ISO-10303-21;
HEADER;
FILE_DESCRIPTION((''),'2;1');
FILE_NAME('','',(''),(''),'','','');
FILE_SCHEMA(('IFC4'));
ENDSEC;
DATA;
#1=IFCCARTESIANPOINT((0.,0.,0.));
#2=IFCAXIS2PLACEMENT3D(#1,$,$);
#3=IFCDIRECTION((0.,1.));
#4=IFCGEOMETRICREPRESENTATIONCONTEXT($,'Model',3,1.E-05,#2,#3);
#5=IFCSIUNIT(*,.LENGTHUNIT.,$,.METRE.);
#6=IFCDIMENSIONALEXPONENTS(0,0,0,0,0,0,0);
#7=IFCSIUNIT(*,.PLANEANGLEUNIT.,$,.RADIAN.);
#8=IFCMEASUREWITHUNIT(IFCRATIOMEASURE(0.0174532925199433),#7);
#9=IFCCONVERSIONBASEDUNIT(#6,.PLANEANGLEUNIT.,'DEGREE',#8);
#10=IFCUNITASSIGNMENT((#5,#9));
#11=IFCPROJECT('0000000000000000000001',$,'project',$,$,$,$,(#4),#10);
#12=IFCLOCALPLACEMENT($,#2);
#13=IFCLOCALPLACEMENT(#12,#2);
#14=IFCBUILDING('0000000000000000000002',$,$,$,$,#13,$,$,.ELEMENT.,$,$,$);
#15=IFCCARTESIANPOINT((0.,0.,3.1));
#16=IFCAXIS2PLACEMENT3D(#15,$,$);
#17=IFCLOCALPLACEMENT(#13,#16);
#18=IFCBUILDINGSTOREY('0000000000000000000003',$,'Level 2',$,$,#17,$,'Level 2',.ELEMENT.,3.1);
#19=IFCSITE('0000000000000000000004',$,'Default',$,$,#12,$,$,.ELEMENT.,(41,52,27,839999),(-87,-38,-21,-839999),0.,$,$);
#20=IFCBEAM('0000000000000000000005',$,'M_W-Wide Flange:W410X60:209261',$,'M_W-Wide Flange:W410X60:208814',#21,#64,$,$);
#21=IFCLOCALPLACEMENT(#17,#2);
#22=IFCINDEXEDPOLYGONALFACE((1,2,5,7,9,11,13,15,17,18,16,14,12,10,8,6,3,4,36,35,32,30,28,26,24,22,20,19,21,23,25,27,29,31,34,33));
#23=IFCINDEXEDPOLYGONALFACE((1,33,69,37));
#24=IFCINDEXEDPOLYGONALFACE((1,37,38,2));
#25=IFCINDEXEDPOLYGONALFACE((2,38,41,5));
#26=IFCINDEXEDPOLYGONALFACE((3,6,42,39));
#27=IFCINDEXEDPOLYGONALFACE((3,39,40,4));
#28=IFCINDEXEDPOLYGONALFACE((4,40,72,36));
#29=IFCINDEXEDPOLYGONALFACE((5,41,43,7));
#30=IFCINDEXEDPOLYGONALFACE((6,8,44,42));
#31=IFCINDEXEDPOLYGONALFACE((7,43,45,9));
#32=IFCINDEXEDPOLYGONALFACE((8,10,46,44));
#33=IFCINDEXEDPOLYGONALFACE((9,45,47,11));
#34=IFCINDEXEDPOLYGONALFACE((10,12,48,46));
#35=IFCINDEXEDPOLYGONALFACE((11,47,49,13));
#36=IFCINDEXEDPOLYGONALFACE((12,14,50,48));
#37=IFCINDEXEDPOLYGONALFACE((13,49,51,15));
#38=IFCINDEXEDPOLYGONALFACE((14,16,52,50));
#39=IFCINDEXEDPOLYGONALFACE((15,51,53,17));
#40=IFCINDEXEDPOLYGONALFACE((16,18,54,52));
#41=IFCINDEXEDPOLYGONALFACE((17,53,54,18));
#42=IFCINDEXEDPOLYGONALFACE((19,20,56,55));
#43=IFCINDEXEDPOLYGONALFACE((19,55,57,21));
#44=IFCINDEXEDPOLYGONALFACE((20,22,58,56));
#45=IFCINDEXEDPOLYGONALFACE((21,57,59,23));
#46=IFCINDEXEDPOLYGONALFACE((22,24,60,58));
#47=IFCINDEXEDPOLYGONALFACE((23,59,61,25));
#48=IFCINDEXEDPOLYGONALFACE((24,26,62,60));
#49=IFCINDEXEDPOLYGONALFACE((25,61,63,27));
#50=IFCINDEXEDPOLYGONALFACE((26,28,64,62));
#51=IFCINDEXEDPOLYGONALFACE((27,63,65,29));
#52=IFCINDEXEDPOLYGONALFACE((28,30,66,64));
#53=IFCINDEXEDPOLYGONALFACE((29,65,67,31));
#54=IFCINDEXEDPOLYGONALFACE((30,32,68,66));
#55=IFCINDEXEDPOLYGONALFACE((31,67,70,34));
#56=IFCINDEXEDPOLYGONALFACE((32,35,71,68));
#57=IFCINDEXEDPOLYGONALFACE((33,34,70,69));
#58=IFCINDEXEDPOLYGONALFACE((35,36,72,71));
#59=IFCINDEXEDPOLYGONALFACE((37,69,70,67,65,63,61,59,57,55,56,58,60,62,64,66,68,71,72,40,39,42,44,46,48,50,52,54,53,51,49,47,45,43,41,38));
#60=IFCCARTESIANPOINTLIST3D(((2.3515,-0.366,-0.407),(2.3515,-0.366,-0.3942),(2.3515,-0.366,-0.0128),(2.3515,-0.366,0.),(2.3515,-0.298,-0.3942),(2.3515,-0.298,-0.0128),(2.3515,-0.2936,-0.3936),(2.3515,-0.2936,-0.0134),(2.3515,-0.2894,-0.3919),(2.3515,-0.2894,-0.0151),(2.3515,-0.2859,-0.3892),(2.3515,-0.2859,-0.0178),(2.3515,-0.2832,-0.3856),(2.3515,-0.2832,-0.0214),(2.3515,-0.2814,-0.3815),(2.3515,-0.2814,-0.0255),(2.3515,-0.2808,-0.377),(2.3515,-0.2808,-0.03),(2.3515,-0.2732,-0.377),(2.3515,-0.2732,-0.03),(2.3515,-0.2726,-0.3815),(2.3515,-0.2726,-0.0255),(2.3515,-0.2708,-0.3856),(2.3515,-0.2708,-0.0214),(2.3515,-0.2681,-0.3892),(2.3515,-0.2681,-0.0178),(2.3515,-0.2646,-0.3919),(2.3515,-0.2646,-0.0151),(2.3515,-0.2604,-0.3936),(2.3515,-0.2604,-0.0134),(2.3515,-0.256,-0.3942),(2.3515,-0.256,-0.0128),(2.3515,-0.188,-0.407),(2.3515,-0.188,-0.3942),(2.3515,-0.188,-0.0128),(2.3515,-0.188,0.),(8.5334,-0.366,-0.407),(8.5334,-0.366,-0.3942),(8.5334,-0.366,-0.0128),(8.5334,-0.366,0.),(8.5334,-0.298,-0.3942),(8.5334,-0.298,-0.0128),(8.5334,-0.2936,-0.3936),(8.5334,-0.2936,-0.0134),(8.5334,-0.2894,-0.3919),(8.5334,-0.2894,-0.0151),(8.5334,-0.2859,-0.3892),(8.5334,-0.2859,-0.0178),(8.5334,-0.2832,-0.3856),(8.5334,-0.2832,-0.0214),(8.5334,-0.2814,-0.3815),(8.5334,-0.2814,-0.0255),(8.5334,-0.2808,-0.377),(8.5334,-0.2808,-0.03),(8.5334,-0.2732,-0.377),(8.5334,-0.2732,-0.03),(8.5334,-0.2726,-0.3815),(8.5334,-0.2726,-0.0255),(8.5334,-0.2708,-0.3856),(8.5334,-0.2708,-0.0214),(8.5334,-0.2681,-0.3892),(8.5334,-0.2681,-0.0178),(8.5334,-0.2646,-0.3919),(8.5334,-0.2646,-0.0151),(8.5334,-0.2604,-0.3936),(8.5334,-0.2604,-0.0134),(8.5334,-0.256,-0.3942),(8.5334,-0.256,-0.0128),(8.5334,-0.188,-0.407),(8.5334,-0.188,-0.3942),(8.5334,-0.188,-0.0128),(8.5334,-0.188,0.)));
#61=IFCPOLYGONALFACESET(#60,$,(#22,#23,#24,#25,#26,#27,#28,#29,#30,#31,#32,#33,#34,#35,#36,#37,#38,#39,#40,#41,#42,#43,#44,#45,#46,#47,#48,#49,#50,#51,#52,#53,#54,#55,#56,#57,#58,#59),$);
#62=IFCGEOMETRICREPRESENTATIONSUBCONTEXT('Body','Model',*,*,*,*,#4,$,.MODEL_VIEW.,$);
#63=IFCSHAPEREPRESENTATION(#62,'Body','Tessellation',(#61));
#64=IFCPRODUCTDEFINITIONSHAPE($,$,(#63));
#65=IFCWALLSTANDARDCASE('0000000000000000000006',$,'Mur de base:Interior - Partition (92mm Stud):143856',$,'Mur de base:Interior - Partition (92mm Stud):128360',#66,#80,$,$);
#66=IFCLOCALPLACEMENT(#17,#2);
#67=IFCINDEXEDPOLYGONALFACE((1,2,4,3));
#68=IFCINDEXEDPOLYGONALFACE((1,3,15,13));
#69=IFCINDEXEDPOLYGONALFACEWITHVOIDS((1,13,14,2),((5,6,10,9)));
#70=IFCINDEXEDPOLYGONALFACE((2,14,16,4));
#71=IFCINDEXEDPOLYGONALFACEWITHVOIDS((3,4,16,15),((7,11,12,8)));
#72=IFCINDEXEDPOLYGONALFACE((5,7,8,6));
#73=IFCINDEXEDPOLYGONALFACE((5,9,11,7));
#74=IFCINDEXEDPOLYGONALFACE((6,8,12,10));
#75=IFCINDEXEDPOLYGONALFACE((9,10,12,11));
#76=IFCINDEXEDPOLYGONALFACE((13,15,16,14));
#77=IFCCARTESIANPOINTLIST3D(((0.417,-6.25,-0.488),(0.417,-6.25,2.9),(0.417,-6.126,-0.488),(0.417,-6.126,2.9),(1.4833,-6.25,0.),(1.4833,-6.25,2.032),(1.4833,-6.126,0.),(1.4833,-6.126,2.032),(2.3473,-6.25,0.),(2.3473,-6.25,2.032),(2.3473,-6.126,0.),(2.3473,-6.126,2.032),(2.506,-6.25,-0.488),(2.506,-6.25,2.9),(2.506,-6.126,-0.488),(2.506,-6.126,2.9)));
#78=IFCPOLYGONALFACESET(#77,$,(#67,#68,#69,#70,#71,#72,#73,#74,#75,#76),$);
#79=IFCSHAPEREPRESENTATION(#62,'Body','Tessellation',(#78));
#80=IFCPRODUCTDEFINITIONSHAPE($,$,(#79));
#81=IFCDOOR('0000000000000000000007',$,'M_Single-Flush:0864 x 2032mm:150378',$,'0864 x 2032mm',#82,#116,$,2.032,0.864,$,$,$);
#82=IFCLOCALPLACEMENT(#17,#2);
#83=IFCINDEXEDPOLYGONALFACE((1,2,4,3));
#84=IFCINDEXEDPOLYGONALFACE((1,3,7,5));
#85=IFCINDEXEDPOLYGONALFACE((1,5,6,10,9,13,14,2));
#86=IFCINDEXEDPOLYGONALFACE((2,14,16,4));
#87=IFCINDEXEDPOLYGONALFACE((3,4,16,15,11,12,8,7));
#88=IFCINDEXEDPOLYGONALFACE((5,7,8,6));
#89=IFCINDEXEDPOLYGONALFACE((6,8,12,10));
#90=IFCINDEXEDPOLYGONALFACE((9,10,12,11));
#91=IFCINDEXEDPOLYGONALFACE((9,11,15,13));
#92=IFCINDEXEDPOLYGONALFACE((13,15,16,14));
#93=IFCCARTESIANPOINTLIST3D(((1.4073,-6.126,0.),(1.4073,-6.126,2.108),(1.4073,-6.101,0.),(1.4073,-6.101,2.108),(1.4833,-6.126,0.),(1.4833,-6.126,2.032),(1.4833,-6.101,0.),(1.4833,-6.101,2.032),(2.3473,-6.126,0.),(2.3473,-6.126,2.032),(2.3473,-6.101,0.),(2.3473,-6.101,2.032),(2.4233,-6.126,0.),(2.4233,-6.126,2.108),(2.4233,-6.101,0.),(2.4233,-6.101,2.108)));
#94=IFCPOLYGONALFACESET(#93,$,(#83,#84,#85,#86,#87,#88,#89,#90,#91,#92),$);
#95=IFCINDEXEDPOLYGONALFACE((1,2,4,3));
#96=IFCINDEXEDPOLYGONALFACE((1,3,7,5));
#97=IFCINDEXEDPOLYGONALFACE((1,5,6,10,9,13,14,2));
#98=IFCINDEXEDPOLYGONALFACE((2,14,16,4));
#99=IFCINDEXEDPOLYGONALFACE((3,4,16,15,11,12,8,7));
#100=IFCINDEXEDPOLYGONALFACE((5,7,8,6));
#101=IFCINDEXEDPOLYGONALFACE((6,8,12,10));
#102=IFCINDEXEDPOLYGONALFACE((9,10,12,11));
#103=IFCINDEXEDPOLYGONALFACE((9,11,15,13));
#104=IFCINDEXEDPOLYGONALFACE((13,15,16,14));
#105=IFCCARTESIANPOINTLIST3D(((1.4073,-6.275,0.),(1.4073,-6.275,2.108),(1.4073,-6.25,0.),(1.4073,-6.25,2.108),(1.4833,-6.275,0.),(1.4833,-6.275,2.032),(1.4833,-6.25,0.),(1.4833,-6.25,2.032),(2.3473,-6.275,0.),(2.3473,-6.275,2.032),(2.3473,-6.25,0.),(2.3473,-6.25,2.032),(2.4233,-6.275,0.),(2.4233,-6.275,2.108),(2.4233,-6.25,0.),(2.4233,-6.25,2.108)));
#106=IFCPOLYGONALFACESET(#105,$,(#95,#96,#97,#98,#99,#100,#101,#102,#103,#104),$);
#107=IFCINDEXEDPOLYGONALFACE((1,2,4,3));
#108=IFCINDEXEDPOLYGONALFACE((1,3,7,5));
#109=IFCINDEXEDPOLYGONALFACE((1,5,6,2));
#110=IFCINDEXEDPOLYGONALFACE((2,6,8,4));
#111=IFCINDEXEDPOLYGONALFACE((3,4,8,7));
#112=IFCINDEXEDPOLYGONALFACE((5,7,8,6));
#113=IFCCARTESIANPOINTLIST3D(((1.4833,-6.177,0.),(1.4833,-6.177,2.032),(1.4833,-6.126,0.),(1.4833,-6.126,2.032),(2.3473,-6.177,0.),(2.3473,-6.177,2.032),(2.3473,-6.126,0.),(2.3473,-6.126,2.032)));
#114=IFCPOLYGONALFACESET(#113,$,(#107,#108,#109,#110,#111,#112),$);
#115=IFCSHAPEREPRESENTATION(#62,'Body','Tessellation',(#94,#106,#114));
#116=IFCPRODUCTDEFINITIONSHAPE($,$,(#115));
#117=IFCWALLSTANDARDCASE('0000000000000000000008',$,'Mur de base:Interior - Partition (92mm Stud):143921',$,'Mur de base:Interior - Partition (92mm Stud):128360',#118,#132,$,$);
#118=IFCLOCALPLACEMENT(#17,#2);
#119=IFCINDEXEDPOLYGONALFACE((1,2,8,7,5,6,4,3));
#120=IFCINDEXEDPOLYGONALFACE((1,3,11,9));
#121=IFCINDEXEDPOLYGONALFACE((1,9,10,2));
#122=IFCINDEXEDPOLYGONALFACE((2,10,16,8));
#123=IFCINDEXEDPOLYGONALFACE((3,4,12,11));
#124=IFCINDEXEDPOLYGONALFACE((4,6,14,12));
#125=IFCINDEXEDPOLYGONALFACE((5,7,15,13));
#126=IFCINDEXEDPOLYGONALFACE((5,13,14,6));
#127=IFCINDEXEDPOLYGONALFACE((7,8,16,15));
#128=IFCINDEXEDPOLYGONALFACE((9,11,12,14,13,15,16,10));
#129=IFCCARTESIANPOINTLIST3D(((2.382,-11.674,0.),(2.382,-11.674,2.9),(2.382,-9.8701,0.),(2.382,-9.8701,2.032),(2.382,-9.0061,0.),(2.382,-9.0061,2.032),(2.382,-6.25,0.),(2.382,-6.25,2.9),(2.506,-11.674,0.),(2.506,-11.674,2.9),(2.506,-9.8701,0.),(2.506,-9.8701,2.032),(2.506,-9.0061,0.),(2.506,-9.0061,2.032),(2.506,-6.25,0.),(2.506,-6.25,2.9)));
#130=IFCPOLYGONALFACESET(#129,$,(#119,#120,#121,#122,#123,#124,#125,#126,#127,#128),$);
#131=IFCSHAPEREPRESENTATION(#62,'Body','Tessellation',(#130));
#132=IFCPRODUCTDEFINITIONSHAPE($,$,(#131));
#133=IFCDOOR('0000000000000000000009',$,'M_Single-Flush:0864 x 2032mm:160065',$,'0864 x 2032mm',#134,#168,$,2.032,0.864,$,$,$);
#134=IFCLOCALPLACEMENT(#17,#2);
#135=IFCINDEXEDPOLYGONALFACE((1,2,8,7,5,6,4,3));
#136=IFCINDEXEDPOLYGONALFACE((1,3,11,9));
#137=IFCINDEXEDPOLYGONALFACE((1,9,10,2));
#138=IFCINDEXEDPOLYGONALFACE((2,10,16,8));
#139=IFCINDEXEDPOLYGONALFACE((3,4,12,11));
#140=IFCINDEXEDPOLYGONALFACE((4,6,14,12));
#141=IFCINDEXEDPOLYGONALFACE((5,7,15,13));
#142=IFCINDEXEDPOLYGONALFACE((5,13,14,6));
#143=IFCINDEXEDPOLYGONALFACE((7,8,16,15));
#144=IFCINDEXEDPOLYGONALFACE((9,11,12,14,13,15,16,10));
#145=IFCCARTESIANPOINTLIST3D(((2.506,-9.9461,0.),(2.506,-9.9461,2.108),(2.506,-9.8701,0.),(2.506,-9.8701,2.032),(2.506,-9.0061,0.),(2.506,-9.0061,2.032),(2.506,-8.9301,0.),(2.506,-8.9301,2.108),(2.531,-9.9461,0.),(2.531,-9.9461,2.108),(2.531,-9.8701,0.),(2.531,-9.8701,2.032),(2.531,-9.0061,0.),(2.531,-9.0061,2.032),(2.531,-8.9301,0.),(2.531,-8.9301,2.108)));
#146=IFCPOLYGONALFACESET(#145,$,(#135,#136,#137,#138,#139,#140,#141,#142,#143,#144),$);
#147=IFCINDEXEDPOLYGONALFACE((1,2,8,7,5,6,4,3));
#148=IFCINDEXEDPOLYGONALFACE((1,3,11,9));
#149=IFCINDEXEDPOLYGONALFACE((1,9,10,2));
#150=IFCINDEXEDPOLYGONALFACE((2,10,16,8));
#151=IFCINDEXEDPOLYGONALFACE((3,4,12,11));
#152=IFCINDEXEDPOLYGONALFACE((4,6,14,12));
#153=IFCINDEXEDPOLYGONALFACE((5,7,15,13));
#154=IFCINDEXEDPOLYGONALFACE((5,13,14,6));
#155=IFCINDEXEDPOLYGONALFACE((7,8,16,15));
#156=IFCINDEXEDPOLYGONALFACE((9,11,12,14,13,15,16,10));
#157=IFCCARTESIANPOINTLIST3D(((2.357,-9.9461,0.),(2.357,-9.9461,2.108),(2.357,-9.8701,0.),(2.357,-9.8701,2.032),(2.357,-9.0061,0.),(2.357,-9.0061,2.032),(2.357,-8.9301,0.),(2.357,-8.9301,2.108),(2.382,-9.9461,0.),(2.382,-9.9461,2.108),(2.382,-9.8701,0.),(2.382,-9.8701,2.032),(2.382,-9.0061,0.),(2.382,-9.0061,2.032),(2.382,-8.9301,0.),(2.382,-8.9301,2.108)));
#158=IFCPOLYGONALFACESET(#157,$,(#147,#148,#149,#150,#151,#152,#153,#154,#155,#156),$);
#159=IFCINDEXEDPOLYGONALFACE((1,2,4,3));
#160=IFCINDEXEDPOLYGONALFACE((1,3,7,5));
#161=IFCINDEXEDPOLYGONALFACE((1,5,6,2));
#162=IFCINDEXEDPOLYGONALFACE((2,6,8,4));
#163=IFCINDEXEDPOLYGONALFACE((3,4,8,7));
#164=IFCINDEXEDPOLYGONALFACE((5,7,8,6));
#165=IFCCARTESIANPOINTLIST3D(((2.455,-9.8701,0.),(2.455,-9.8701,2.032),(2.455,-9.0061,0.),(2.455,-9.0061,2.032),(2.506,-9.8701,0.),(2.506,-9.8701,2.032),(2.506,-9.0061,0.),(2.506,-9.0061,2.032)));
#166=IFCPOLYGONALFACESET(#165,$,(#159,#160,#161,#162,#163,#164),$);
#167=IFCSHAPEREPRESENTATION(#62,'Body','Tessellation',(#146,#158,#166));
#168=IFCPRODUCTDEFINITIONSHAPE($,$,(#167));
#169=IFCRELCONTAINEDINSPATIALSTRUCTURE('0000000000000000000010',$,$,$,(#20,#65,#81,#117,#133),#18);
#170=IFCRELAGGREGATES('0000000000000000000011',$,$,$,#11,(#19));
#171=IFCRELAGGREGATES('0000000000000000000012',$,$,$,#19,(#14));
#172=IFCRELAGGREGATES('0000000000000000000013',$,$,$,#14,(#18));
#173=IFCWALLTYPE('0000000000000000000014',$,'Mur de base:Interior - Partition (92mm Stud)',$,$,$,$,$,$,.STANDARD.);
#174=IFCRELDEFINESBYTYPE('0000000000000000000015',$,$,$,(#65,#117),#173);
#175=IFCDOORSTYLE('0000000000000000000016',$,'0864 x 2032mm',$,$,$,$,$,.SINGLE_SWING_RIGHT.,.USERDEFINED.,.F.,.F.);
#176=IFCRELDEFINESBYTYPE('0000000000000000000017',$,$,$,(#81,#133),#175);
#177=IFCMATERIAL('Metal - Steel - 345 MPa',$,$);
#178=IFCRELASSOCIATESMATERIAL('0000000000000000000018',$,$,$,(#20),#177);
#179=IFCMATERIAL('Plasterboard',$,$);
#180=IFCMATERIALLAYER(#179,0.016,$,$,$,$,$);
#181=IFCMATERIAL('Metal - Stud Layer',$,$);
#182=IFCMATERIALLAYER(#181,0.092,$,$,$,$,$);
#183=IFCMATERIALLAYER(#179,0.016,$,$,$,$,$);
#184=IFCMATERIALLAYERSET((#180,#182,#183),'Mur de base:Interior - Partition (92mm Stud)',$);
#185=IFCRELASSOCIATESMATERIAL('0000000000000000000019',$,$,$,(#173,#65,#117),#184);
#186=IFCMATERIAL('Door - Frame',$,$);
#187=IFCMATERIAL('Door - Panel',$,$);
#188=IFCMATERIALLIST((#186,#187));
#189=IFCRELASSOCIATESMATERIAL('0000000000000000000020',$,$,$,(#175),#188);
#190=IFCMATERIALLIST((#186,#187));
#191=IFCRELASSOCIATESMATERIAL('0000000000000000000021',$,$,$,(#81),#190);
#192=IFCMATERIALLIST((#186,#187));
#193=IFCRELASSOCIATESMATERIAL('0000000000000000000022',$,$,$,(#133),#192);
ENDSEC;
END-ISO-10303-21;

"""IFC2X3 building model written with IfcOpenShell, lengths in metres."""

from ifc_helpers import new_model, entity, si_unit, converted_unit, direction, frame, frame_2d, origin, origin_2d_with_axis, place, context, subcontext, project, spatial, polyline, rectangle, i_section, outline, extrude, source, transform, mapped, material, material_list, layer, layer_set, layer_usage, type_object, type_shapes, element, fill, save


model = new_model("IFC2X3")

# Units and contexts
model_context = context("Model", 3, precision=1e-05, world=origin(), true_north=direction((0.0, 1.0)))
body_context = subcontext(model_context, "Body", "Model", "MODEL_VIEW")
ifc_project = project(units=[si_unit("LENGTHUNIT", "METRE"), converted_unit("PLANEANGLEUNIT", "DEGREE", entity("IfcRatioMeasure", 0.0174532925199433), si_unit("PLANEANGLEUNIT", "RADIAN"), dimensions=[0, 0, 0, 0, 0, 0, 0])], contexts=[model_context])

# Site, building, storey
site_placement = place(None, origin())
site = spatial("IfcSite", under=ifc_project, at=site_placement, Name="Default", CompositionType="ELEMENT", RefLatitude=(41, 52, 27, 839999), RefLongitude=(-87, -38, -21, -839999), RefElevation=0.0)
building_placement = place(site_placement, origin())
building = spatial("IfcBuilding", under=site, at=building_placement, CompositionType="ELEMENT")
storey_placement = place(building_placement, frame((0.0, 0.0, 3.1)))
storey = spatial("IfcBuildingStorey", under=building, at=storey_placement, Name="Level 2", LongName="Level 2", CompositionType="ELEMENT", Elevation=3.1)

# Beam
ifc_material_1 = material(Name="Metal - Steel - 345 MPa")
beam_placement = place(storey_placement, frame((8.5334, -0.277, 0.0), z_axis=(0.0, 0.0, 1.0), x_axis=(-1.0, 0.0, 0.0)))
element("IfcBeam", 1, at=beam_placement, inside=storey, material=ifc_material_1, Name="M_W-Wide Flange:W410X60:209261", ObjectType="M_W-Wide Flange:W410X60:208814", context=body_context, shape_type="SweptSolid", body=[
    extrude(i_section(OverallWidth=0.178, OverallDepth=0.407, WebThickness=0.0077, FlangeThickness=0.0128, FilletRadius=0.0172, at=frame_2d((0.0, 0.0), x_axis=(0.0, 1.0))), frame((0.0, 0.0, -0.2035), z_axis=(1.0, 0.0, 0.0), x_axis=(0.0, 0.0, -1.0)), (0.0, 0.0, 1.0), 6.1819),
])

# Shared definitions
ifc_material_2 = material(Name="Metal - Stud Layer")
ifc_material_3 = material(Name="Plasterboard")

# Walls, openings, doors
ifc_layer_1 = layer(ifc_material_3, 0.016)
ifc_layer_2 = layer(ifc_material_2, 0.092)
ifc_layer_3 = layer(ifc_material_3, 0.016)
ifc_layer_set_1 = layer_set([ifc_layer_1, ifc_layer_2, ifc_layer_3], Name="Mur de base:Interior - Partition (92mm Stud)")
ifc_layer_usage_1 = layer_usage(ifc_layer_set_1, "AXIS2", "NEGATIVE", 0.062)
wall_type_1 = type_object("IfcWallType", Name="Mur de base:Interior - Partition (92mm Stud)", PredefinedType="STANDARD", material=ifc_layer_set_1)
wall_1_placement = place(storey_placement, frame((0.417, -6.188, -0.488)))
wall_1 = element("IfcWallStandardCase", 2, at=wall_1_placement, inside=storey, type_object=wall_type_1, material=ifc_layer_usage_1, Name="Mur de base:Interior - Partition (92mm Stud):143856", ObjectType="Mur de base:Interior - Partition (92mm Stud):128360", context=body_context, shape_type="SweptSolid", body=[
    extrude(rectangle(XDim=2.089, YDim=0.124, at=frame_2d((1.0445, 0.0), x_axis=(-1.0, 0.0))), origin(), (0.0, 0.0, 1.0), 3.388),
])
opening_1_placement = place(wall_1_placement, frame((1.0663, -0.062, 0.488)))
opening_1 = element("IfcOpeningElement", 3, at=opening_1_placement, cuts=wall_1, ObjectType="Opening", context=body_context, shape_type="SweptSolid", body=[
    extrude(rectangle(XDim=0.864, YDim=2.032, at=frame_2d((1.016, 0.432), x_axis=(0.0, 1.0))), frame((0.0, 0.0, 0.0), z_axis=(0.0, 1.0, 0.0), x_axis=(0.0, 0.0, 1.0)), (0.0, 0.0, 1.0), 0.124),
])
ifc_material_4 = material(Name="Door - Frame")
ifc_material_5 = material(Name="Door - Panel")
ifc_material_list_1 = material_list([ifc_material_4, ifc_material_5])
ifc_material_list_2 = material_list([ifc_material_4, ifc_material_5])
door_style_1 = type_object("IfcDoorStyle", Name="0864 x 2032mm", ConstructionType="USERDEFINED", OperationType="SINGLE_SWING_RIGHT", ParameterTakesPrecedence=False, Sizeable=False, material=ifc_material_list_2)
shared_shape_1 = source(origin(), body_context, "Body", "SweptSolid", [
    extrude(outline(polyline([(-0.508, -1.073), (0.508, -1.073), (0.508, 1.035), (0.432, 1.035), (0.432, -0.997), (-0.432, -0.997), (-0.432, 1.035), (-0.508, 1.035), (-0.508, -1.073)])), frame((0.432, 0.124, 1.035), z_axis=(0.0, 1.0, 0.0), x_axis=(1.0, 0.0, 0.0)), (0.0, 0.0, 1.0), 0.025),
    extrude(outline(polyline([(-1.073, -0.508), (1.035, -0.508), (1.035, -0.432), (-0.997, -0.432), (-0.997, 0.432), (1.035, 0.432), (1.035, 0.508), (-1.073, 0.508), (-1.073, -0.508)])), frame((0.432, -0.025, 1.035), z_axis=(0.0, 1.0, 0.0), x_axis=(0.0, 0.0, -1.0)), (0.0, 0.0, 1.0), 0.025),
    extrude(rectangle(XDim=0.051, YDim=0.864, at=origin_2d_with_axis()), frame((0.432, 0.0985, 0.0), z_axis=(0.0, 0.0, 1.0), x_axis=(0.0, 1.0, 0.0)), (0.0, 0.0, 1.0), 2.032),
])
type_shapes(door_style_1, [shared_shape_1])
door_1_placement = place(opening_1_placement, origin())
door_1 = element("IfcDoor", 4, at=door_1_placement, inside=storey, type_object=door_style_1, material=ifc_material_list_1, Name="M_Single-Flush:0864 x 2032mm:150378", ObjectType="0864 x 2032mm", OverallHeight=2.032, OverallWidth=0.864, context=body_context, shape_type="MappedRepresentation", body=[
    mapped(shared_shape_1, transform((0.0, 0.0, 0.0), scale=1.0)),
])
fill(opening_1, door_1)
ifc_layer_usage_2 = layer_usage(ifc_layer_set_1, "AXIS2", "NEGATIVE", 0.062)
wall_2_placement = place(storey_placement, frame((2.444, -6.25, 0.0), z_axis=(0.0, 0.0, 1.0), x_axis=(0.0, -1.0, 0.0)))
wall_2 = element("IfcWallStandardCase", 5, at=wall_2_placement, inside=storey, type_object=wall_type_1, material=ifc_layer_usage_2, Name="Mur de base:Interior - Partition (92mm Stud):143921", ObjectType="Mur de base:Interior - Partition (92mm Stud):128360", context=body_context, shape_type="SweptSolid", body=[
    extrude(rectangle(XDim=5.424, YDim=0.124, at=frame_2d((2.712, 0.0), x_axis=(-1.0, 0.0))), origin(), (0.0, 0.0, 1.0), 2.9),
])
opening_2_placement = place(wall_2_placement, frame((2.7561, -0.062, 0.0)))
opening_2 = element("IfcOpeningElement", 6, at=opening_2_placement, cuts=wall_2, ObjectType="Opening", context=body_context, shape_type="SweptSolid", body=[
    extrude(rectangle(XDim=0.864, YDim=2.032, at=frame_2d((1.016, 0.432), x_axis=(0.0, 1.0))), frame((0.0, 0.0, 0.0), z_axis=(0.0, 1.0, 0.0), x_axis=(0.0, 0.0, 1.0)), (0.0, 0.0, 1.0), 0.124),
])
ifc_material_list_3 = material_list([ifc_material_4, ifc_material_5])
door_2_placement = place(opening_2_placement, origin())
door_2 = element("IfcDoor", 7, at=door_2_placement, inside=storey, type_object=door_style_1, material=ifc_material_list_3, Name="M_Single-Flush:0864 x 2032mm:160065", ObjectType="0864 x 2032mm", OverallHeight=2.032, OverallWidth=0.864, context=body_context, shape_type="MappedRepresentation", body=[
    mapped(shared_shape_1, transform((0.0, 0.0, 0.0), scale=1.0)),
])
fill(opening_2, door_2)

save(model, "model.ifc")
